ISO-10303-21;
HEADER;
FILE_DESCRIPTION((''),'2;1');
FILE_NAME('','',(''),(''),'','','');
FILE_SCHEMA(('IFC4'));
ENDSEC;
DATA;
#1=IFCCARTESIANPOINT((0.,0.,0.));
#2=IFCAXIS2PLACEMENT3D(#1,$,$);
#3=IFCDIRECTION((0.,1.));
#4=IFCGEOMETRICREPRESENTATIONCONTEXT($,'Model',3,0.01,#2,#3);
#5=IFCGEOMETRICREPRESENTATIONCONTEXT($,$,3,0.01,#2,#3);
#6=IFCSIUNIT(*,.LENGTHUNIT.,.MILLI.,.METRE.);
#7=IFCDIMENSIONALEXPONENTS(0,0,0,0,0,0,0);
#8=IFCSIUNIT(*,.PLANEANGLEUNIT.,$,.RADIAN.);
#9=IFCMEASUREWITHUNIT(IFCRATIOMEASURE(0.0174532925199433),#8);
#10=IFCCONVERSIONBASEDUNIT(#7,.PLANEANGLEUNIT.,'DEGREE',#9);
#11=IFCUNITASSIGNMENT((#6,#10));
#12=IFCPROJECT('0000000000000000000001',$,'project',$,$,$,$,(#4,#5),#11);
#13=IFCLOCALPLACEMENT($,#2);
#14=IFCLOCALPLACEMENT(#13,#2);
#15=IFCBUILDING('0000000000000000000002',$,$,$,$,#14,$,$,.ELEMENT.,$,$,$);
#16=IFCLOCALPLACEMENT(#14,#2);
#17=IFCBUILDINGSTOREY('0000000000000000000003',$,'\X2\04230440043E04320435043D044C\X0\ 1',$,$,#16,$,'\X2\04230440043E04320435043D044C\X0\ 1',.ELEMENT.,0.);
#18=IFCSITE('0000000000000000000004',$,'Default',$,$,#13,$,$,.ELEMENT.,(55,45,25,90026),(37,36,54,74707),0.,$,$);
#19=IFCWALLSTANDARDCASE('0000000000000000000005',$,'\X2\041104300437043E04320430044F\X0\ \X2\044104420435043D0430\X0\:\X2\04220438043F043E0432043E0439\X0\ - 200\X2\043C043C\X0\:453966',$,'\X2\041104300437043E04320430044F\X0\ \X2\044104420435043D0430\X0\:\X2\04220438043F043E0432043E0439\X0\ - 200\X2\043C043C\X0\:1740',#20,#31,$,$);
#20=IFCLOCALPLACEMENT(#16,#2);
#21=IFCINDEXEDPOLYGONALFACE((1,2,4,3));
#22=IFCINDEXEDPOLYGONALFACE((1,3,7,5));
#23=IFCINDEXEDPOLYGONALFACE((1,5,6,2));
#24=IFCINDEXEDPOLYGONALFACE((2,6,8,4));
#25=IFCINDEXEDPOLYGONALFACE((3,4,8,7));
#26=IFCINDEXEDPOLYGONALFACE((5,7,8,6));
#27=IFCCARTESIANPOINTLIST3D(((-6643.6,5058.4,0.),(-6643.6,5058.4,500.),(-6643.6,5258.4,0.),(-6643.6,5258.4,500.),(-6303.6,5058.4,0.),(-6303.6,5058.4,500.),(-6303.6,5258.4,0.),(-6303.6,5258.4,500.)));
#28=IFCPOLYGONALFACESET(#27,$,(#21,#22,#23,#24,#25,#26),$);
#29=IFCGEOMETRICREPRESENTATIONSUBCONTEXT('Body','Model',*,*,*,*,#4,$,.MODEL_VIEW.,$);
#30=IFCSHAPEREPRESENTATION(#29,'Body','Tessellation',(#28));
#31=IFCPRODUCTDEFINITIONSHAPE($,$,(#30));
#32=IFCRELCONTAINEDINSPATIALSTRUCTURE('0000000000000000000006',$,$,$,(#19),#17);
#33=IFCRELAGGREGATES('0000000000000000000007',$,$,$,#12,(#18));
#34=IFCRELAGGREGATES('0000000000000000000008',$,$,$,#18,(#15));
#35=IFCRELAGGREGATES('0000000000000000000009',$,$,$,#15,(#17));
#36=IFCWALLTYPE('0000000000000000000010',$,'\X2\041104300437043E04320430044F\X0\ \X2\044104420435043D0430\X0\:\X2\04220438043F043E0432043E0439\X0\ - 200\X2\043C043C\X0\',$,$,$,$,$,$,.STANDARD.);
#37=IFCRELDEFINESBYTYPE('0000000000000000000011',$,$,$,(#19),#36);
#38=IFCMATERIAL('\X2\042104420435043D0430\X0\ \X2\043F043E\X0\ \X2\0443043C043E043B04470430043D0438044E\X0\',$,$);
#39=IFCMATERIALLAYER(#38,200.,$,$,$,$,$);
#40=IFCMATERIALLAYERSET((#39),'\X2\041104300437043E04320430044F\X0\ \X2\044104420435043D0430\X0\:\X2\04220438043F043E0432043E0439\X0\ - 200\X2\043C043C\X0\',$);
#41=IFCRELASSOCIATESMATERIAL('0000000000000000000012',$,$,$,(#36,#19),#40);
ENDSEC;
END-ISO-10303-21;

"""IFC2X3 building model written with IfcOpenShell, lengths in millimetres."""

from ifc_helpers import new_model, entity, si_unit, converted_unit, direction, frame, frame_2d, origin, place, context, subcontext, project, spatial, rectangle, extrude, material, layer, layer_set, layer_usage, type_object, element, save


model = new_model("IFC2X3")

# Units and contexts
model_context = context("Model", 3, precision=0.01, world=origin(), true_north=direction((0.0, 1.0)))
context_of_model = context(None, 3, precision=0.01, world=origin(), true_north=direction((0.0, 1.0)))
body_context = subcontext(model_context, "Body", "Model", "MODEL_VIEW")
ifc_project = project(units=[si_unit("LENGTHUNIT", "METRE", prefix="MILLI"), converted_unit("PLANEANGLEUNIT", "DEGREE", entity("IfcRatioMeasure", 0.0174532925199433), si_unit("PLANEANGLEUNIT", "RADIAN"), dimensions=[0, 0, 0, 0, 0, 0, 0])], contexts=[model_context, context_of_model])

# Site, building, storey
site_placement = place(None, origin())
site = spatial("IfcSite", under=ifc_project, at=site_placement, Name="Default", CompositionType="ELEMENT", RefLatitude=(55, 45, 25, 90026), RefLongitude=(37, 36, 54, 74707), RefElevation=0.0)
building_placement = place(site_placement, origin())
building = spatial("IfcBuilding", under=site, at=building_placement, CompositionType="ELEMENT")
storey_placement = place(building_placement, origin())
storey = spatial("IfcBuildingStorey", under=building, at=storey_placement, Name="Уровень 1", LongName="Уровень 1", CompositionType="ELEMENT", Elevation=0.0)

# Wall
ifc_material = material(Name="Стена по умолчанию")
ifc_layer = layer(ifc_material, 200.0)
ifc_layer_set = layer_set([ifc_layer], Name="Базовая стена:Типовой - 200мм")
ifc_layer_usage = layer_usage(ifc_layer_set, "AXIS2", "NEGATIVE", 100.0)
wall_type = type_object("IfcWallType", Name="Базовая стена:Типовой - 200мм", PredefinedType="STANDARD", material=ifc_layer_set)
wall_placement = place(storey_placement, frame((-6643.6, 5158.4, 0.0)))
element("IfcWallStandardCase", 1, at=wall_placement, inside=storey, type_object=wall_type, material=ifc_layer_usage, Name="Базовая стена:Типовой - 200мм:453966", ObjectType="Базовая стена:Типовой - 200мм:1740", context=body_context, shape_type="SweptSolid", body=[
    extrude(rectangle(XDim=340.0, YDim=200.0, at=frame_2d((170.0, 0.0), x_axis=(-1.0, 0.0))), origin(), (0.0, 0.0, 1.0), 500.0),
])

save(model, "model.ifc")
